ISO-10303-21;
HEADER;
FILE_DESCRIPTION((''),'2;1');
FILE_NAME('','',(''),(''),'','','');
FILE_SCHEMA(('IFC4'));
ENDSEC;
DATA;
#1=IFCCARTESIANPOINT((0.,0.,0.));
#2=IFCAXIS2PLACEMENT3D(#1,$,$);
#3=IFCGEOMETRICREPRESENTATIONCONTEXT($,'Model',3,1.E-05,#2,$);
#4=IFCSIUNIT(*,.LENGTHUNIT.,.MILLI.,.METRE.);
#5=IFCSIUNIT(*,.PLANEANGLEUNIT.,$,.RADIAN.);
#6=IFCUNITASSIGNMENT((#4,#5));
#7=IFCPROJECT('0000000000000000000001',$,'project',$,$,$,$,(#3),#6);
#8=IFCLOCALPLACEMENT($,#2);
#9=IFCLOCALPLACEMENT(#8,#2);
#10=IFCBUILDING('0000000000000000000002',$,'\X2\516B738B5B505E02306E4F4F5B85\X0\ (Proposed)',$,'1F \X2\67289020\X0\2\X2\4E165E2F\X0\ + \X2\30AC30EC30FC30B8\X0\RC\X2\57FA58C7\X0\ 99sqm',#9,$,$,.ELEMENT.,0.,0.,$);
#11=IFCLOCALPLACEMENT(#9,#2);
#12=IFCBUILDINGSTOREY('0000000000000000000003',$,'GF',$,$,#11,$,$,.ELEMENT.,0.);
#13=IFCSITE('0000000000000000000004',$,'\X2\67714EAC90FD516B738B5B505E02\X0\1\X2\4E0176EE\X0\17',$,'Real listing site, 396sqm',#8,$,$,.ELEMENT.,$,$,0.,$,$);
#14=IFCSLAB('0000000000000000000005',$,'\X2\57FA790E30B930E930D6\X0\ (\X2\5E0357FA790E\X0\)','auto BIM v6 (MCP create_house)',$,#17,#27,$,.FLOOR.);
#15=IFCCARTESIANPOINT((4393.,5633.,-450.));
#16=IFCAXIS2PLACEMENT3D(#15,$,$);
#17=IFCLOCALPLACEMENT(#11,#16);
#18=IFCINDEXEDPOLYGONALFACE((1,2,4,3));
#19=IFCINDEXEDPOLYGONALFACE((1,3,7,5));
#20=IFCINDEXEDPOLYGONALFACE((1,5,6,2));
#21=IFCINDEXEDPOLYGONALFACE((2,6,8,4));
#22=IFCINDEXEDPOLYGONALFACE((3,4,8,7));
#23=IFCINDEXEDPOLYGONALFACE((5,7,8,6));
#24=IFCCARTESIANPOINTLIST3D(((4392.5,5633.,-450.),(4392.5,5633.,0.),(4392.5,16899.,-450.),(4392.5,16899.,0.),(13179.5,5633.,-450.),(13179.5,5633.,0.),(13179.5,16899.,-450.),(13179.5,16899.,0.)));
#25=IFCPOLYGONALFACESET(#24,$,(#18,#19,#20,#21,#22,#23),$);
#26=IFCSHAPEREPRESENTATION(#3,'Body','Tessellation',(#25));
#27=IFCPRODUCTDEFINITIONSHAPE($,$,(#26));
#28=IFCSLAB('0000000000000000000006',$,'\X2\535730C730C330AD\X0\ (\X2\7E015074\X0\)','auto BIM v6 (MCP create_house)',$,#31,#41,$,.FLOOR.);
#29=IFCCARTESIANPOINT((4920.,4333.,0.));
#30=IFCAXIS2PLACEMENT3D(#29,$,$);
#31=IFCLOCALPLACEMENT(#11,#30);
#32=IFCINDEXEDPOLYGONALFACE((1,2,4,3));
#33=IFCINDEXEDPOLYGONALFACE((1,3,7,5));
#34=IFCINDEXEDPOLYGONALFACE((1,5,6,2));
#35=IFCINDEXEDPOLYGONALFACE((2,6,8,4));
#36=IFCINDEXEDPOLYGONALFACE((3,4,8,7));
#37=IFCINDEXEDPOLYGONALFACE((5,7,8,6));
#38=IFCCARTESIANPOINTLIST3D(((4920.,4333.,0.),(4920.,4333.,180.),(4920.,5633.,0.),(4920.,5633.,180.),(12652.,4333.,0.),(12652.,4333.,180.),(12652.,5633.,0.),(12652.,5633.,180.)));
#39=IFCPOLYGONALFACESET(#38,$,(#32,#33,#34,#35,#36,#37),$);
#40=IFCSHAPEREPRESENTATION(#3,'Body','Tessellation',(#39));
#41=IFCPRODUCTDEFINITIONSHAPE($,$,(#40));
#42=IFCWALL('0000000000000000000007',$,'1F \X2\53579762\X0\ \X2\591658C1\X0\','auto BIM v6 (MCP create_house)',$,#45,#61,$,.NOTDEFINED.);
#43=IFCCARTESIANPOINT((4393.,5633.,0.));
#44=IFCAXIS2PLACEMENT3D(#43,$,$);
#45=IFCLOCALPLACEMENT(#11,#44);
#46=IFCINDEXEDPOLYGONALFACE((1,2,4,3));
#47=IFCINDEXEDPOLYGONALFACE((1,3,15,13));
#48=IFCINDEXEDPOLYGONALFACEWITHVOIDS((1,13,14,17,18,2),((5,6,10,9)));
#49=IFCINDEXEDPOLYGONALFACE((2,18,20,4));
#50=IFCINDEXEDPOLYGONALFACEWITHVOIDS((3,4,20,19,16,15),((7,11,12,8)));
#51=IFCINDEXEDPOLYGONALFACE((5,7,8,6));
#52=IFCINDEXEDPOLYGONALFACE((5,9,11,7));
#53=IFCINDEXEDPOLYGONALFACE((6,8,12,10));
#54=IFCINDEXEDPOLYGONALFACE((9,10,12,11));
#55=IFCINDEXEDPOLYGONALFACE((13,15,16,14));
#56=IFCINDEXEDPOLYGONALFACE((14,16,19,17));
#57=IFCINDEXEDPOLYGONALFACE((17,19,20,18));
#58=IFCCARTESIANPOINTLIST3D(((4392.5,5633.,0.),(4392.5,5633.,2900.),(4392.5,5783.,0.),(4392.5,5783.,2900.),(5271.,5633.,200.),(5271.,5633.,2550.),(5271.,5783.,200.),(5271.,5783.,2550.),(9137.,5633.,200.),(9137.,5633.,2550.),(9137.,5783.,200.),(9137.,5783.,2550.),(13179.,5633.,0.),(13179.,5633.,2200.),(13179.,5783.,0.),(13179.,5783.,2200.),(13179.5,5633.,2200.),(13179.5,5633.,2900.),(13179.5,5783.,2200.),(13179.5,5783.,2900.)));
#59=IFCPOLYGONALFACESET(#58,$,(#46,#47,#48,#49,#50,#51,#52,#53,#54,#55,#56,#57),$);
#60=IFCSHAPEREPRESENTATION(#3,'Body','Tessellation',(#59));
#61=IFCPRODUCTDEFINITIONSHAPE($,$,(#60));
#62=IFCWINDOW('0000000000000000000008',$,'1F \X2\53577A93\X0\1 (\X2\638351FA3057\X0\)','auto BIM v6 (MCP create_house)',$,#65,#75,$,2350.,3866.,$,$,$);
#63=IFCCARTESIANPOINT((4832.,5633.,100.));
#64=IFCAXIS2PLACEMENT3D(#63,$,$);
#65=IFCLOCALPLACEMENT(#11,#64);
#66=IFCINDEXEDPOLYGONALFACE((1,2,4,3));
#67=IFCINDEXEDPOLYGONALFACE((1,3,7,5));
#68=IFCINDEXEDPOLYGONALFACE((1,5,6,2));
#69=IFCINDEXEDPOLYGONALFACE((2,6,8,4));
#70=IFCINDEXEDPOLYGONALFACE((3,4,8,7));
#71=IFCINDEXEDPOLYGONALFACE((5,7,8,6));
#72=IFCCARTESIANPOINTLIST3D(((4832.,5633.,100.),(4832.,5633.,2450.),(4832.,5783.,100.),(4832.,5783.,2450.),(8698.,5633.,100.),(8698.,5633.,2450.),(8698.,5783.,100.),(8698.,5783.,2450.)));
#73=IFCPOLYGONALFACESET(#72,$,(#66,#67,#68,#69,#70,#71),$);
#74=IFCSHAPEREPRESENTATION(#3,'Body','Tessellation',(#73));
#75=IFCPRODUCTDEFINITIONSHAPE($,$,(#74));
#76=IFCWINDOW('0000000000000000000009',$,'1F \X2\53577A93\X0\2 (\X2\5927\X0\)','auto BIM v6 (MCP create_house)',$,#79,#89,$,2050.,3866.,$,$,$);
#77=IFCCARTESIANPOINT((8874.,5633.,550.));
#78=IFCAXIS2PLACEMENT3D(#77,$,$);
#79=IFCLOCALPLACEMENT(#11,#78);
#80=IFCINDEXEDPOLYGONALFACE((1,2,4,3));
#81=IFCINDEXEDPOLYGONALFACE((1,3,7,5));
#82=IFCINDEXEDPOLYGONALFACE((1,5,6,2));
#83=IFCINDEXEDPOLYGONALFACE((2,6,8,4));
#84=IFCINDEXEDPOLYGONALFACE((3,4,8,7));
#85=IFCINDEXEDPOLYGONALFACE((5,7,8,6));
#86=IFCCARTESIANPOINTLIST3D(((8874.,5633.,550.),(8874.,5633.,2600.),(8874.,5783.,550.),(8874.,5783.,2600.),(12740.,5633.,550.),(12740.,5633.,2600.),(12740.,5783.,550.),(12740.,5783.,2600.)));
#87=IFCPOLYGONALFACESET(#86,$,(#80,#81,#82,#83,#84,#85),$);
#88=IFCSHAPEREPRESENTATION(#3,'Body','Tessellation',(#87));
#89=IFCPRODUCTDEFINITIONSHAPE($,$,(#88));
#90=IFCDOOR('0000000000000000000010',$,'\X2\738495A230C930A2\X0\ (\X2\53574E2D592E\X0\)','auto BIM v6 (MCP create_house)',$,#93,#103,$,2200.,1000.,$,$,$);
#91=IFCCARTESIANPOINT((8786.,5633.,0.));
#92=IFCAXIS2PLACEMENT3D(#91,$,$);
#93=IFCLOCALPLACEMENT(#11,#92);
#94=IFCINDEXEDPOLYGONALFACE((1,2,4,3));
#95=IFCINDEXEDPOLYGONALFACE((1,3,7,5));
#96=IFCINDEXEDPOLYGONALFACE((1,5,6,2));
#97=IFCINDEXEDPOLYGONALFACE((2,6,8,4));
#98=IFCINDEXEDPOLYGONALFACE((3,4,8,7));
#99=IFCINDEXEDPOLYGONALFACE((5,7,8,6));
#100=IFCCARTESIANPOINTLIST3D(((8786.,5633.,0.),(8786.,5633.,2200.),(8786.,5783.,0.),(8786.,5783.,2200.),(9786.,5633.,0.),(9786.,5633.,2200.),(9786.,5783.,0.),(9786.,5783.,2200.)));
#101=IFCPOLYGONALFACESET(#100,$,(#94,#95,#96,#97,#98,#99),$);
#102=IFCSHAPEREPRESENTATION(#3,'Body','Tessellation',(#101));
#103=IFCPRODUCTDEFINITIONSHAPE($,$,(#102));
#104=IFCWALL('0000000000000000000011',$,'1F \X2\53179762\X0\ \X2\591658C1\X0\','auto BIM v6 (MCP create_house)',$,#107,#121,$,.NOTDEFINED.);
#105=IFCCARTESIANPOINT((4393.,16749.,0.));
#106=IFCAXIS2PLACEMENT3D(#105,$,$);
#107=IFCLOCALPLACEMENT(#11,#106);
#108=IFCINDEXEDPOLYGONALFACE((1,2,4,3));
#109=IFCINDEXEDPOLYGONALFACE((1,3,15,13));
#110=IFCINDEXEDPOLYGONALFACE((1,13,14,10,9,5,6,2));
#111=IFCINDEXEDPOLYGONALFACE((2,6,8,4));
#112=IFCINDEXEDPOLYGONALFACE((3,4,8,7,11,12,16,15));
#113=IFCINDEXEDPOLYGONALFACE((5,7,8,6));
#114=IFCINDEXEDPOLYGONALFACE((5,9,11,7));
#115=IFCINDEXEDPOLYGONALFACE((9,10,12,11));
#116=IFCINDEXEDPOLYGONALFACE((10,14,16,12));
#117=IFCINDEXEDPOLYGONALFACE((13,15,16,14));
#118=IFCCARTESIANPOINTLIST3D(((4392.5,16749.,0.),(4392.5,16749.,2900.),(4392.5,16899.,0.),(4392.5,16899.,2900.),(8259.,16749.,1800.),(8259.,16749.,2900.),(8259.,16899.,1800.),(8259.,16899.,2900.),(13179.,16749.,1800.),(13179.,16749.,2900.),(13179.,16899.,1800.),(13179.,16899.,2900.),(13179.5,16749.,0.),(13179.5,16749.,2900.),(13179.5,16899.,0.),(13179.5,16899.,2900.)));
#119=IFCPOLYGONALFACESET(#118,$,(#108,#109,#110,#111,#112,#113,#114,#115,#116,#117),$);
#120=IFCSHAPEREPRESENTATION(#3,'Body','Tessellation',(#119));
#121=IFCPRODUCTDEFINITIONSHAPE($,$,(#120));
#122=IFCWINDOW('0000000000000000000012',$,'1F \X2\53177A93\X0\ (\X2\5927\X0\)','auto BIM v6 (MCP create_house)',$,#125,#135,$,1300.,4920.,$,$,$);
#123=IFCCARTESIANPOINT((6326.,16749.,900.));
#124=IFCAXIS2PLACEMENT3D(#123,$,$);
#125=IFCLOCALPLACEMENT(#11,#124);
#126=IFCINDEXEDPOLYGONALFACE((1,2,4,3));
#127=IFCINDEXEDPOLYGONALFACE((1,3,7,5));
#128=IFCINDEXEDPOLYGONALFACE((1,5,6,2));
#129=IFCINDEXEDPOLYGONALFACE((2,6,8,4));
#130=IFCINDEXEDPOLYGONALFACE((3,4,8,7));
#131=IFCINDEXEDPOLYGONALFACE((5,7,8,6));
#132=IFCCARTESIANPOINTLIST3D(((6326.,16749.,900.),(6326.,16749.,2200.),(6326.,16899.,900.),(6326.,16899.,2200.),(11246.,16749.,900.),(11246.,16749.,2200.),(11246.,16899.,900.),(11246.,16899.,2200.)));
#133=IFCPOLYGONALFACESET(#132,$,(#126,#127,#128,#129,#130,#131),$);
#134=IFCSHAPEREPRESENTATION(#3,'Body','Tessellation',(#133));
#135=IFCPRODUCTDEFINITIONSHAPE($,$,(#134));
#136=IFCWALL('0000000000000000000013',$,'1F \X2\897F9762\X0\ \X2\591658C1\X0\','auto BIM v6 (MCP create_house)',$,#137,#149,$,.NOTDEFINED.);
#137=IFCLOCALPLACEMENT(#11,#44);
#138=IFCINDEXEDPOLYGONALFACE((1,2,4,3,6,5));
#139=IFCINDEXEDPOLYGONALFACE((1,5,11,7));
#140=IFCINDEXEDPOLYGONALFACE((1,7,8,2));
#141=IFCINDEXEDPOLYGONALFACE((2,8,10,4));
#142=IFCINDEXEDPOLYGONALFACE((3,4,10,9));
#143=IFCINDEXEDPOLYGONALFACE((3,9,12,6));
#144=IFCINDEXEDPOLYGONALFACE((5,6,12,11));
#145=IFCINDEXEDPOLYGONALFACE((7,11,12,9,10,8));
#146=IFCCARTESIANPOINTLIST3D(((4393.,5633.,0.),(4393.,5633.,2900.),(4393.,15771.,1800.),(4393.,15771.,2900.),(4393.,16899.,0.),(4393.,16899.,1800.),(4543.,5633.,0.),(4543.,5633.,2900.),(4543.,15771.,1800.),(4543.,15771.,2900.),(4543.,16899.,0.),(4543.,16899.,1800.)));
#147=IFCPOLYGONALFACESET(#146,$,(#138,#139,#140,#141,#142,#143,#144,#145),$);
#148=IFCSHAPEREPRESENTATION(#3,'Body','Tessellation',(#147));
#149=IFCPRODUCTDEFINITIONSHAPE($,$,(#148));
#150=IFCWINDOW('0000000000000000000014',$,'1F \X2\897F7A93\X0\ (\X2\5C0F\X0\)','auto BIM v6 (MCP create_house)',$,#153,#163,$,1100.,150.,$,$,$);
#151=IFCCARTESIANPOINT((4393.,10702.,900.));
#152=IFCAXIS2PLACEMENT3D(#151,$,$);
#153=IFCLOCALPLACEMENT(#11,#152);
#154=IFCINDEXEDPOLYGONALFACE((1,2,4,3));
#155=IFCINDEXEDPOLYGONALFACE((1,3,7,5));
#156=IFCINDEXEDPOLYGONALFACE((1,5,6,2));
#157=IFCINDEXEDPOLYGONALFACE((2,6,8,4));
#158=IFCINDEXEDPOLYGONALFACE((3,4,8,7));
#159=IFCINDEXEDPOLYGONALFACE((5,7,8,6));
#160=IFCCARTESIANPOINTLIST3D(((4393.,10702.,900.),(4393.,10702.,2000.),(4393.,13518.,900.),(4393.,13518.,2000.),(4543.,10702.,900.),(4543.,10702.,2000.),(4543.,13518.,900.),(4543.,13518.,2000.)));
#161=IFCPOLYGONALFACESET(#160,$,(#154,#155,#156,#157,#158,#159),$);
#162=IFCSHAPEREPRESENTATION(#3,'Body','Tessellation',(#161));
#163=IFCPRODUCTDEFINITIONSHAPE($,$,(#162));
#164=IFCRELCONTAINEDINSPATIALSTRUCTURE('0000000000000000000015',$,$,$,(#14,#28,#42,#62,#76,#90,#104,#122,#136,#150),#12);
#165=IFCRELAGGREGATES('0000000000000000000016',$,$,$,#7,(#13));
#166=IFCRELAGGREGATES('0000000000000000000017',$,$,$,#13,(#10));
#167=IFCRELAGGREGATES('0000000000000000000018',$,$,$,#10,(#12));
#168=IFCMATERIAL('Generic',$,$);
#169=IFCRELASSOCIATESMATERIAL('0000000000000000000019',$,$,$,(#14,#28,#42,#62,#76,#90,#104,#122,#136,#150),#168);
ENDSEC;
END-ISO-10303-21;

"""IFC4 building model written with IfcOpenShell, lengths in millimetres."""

from ifc_helpers import new_model, si_unit, frame, frame_2d, origin, place, context, project, spatial, rectangle, extrude, material, element, fill, save


model = new_model("IFC4")

# Units and contexts
model_context = context("Model", 3, precision=1e-05, world=origin())
ifc_project = project(units=[si_unit("LENGTHUNIT", "METRE", prefix="MILLI"), si_unit("PLANEANGLEUNIT", "RADIAN")], contexts=[model_context])

# Site, building, storey
site_placement = place(None, origin())
site = spatial("IfcSite", under=ifc_project, at=site_placement, Name="東京都八王子市1丁目17", ObjectType="Real listing site, 396sqm", CompositionType="ELEMENT", RefElevation=0.0)
building_placement = place(site_placement, origin())
building = spatial("IfcBuilding", under=site, at=building_placement, Name="八王子市の住宅 (Proposed)", ObjectType="1F 木造2世帯 + ガレージRC基壇 99sqm", CompositionType="ELEMENT", ElevationOfRefHeight=0.0, ElevationOfTerrain=0.0)
storey_placement = place(building_placement, origin())
storey = spatial("IfcBuildingStorey", under=building, at=storey_placement, Name="GF", CompositionType="ELEMENT", Elevation=0.0)

# Slabs
ifc_material = material(Name="Generic")
slab_1_placement = place(storey_placement, frame((4393.0, 5633.0, -450.0)))
element("IfcSlab", 1, at=slab_1_placement, inside=storey, material=ifc_material, Name="基礎スラブ (布基礎)", Description="auto BIM v6 (MCP create_house)", PredefinedType="FLOOR", context=model_context, shape_type="SweptSolid", body=[
    extrude(rectangle(XDim=8787.0, YDim=11266.0, at=frame_2d((4393.0, 5633.0))), frame((4393.0, 5633.0, -450.0)), (0.0, 0.0, 1.0), 450.0),
])
slab_2_placement = place(storey_placement, frame((4920.0, 4333.0, 0.0)))
element("IfcSlab", 2, at=slab_2_placement, inside=storey, material=ifc_material, Name="南デッキ (縁側)", Description="auto BIM v6 (MCP create_house)", PredefinedType="FLOOR", context=model_context, shape_type="SweptSolid", body=[
    extrude(rectangle(XDim=7732.0, YDim=1300.0, at=frame_2d((3866.0, 650.0))), frame((4920.0, 4333.0, 0.0)), (0.0, 0.0, 1.0), 180.0),
])

# Wall, openings, windows, door
wall_1_placement = place(storey_placement, frame((4393.0, 5633.0, 0.0)))
wall_1 = element("IfcWall", 3, at=wall_1_placement, inside=storey, material=ifc_material, Name="1F 南面 外壁", Description="auto BIM v6 (MCP create_house)", PredefinedType="NOTDEFINED", context=model_context, shape_type="SweptSolid", body=[
    extrude(rectangle(XDim=8787.0, YDim=150.0, at=frame_2d((4393.0, 75.0))), frame((4393.0, 5633.0, 0.0)), (0.0, 0.0, 1.0), 2900.0),
])
opening_1_placement = place(storey_placement, frame((4832.0, 5633.0, 100.0)))
opening_1 = element("IfcOpeningElement", 4, at=opening_1_placement, cuts=wall_1, PredefinedType="NOTDEFINED", context=model_context, shape_type="SweptSolid", body=[
    extrude(rectangle(XDim=3866.0, YDim=150.0, at=frame_2d((1933.0, 75.0))), frame((4832.0, 5633.0, 100.0)), (0.0, 0.0, 1.0), 2350.0),
])
opening_2_placement = place(storey_placement, frame((8874.0, 5633.0, 550.0)))
opening_2 = element("IfcOpeningElement", 5, at=opening_2_placement, cuts=wall_1, PredefinedType="NOTDEFINED", context=model_context, shape_type="SweptSolid", body=[
    extrude(rectangle(XDim=3866.0, YDim=150.0, at=frame_2d((1933.0, 75.0))), frame((8874.0, 5633.0, 550.0)), (0.0, 0.0, 1.0), 2050.0),
])
opening_3_placement = place(storey_placement, frame((8786.0, 5633.0, 0.0)))
opening_3 = element("IfcOpeningElement", 6, at=opening_3_placement, cuts=wall_1, PredefinedType="NOTDEFINED", context=model_context, shape_type="SweptSolid", body=[
    extrude(rectangle(XDim=1000.0, YDim=150.0, at=frame_2d((500.0, 75.0))), frame((8786.0, 5633.0, 0.0)), (0.0, 0.0, 1.0), 2200.0),
])
window_1_placement = place(storey_placement, frame((4832.0, 5633.0, 100.0)))
window_1 = element("IfcWindow", 7, at=window_1_placement, inside=storey, material=ifc_material, Name="1F 南窓1 (掃出し)", Description="auto BIM v6 (MCP create_house)", OverallHeight=2350.0, OverallWidth=3866.0, context=model_context, shape_type="SweptSolid", body=[
    extrude(rectangle(XDim=3866.0, YDim=150.0, at=frame_2d((1933.0, 75.0))), frame((4832.0, 5633.0, 100.0)), (0.0, 0.0, 1.0), 2350.0),
])
fill(opening_1, window_1)
window_2_placement = place(storey_placement, frame((8874.0, 5633.0, 550.0)))
window_2 = element("IfcWindow", 8, at=window_2_placement, inside=storey, material=ifc_material, Name="1F 南窓2 (大)", Description="auto BIM v6 (MCP create_house)", OverallHeight=2050.0, OverallWidth=3866.0, context=model_context, shape_type="SweptSolid", body=[
    extrude(rectangle(XDim=3866.0, YDim=150.0, at=frame_2d((1933.0, 75.0))), frame((8874.0, 5633.0, 550.0)), (0.0, 0.0, 1.0), 2050.0),
])
fill(opening_2, window_2)
door_placement = place(storey_placement, frame((8786.0, 5633.0, 0.0)))
door = element("IfcDoor", 9, at=door_placement, inside=storey, material=ifc_material, Name="玄関ドア (南中央)", Description="auto BIM v6 (MCP create_house)", OverallHeight=2200.0, OverallWidth=1000.0, context=model_context, shape_type="SweptSolid", body=[
    extrude(rectangle(XDim=1000.0, YDim=150.0, at=frame_2d((500.0, 75.0))), frame((8786.0, 5633.0, 0.0)), (0.0, 0.0, 1.0), 2200.0),
])
fill(opening_3, door)

# Walls, openings, windows
wall_2_placement = place(storey_placement, frame((4393.0, 16749.0, 0.0)))
wall_2 = element("IfcWall", 10, at=wall_2_placement, inside=storey, material=ifc_material, Name="1F 北面 外壁", Description="auto BIM v6 (MCP create_house)", PredefinedType="NOTDEFINED", context=model_context, shape_type="SweptSolid", body=[
    extrude(rectangle(XDim=8787.0, YDim=150.0, at=frame_2d((4393.0, 75.0))), frame((4393.0, 16749.0, 0.0)), (0.0, 0.0, 1.0), 2900.0),
])
opening_4_placement = place(storey_placement, frame((6326.0, 16749.0, 900.0)))
opening_4 = element("IfcOpeningElement", 11, at=opening_4_placement, cuts=wall_2, PredefinedType="NOTDEFINED", context=model_context, shape_type="SweptSolid", body=[
    extrude(rectangle(XDim=4920.0, YDim=150.0, at=frame_2d((2460.0, 75.0))), frame((6326.0, 16749.0, 900.0)), (0.0, 0.0, 1.0), 1300.0),
])
window_3_placement = place(storey_placement, frame((6326.0, 16749.0, 900.0)))
window_3 = element("IfcWindow", 12, at=window_3_placement, inside=storey, material=ifc_material, Name="1F 北窓 (大)", Description="auto BIM v6 (MCP create_house)", OverallHeight=1300.0, OverallWidth=4920.0, context=model_context, shape_type="SweptSolid", body=[
    extrude(rectangle(XDim=4920.0, YDim=150.0, at=frame_2d((2460.0, 75.0))), frame((6326.0, 16749.0, 900.0)), (0.0, 0.0, 1.0), 1300.0),
])
fill(opening_4, window_3)
wall_3_placement = place(storey_placement, frame((4393.0, 5633.0, 0.0)))
wall_3 = element("IfcWall", 13, at=wall_3_placement, inside=storey, material=ifc_material, Name="1F 西面 外壁", Description="auto BIM v6 (MCP create_house)", PredefinedType="NOTDEFINED", context=model_context, shape_type="SweptSolid", body=[
    extrude(rectangle(XDim=150.0, YDim=11266.0, at=frame_2d((75.0, 5633.0))), frame((4393.0, 5633.0, 0.0)), (0.0, 0.0, 1.0), 2900.0),
])
opening_5_placement = place(storey_placement, frame((4393.0, 10702.0, 900.0)))
opening_5 = element("IfcOpeningElement", 14, at=opening_5_placement, cuts=wall_3, PredefinedType="NOTDEFINED", context=model_context, shape_type="SweptSolid", body=[
    extrude(rectangle(XDim=150.0, YDim=2816.0, at=frame_2d((75.0, 1408.0))), frame((4393.0, 10702.0, 900.0)), (0.0, 0.0, 1.0), 1100.0),
])
window_4_placement = place(storey_placement, frame((4393.0, 10702.0, 900.0)))
window_4 = element("IfcWindow", 15, at=window_4_placement, inside=storey, material=ifc_material, Name="1F 西窓 (小)", Description="auto BIM v6 (MCP create_house)", OverallHeight=1100.0, OverallWidth=150.0, context=model_context, shape_type="SweptSolid", body=[
    extrude(rectangle(XDim=150.0, YDim=2816.0, at=frame_2d((75.0, 1408.0))), frame((4393.0, 10702.0, 900.0)), (0.0, 0.0, 1.0), 1100.0),
])
fill(opening_5, window_4)

save(model, "model.ifc")
